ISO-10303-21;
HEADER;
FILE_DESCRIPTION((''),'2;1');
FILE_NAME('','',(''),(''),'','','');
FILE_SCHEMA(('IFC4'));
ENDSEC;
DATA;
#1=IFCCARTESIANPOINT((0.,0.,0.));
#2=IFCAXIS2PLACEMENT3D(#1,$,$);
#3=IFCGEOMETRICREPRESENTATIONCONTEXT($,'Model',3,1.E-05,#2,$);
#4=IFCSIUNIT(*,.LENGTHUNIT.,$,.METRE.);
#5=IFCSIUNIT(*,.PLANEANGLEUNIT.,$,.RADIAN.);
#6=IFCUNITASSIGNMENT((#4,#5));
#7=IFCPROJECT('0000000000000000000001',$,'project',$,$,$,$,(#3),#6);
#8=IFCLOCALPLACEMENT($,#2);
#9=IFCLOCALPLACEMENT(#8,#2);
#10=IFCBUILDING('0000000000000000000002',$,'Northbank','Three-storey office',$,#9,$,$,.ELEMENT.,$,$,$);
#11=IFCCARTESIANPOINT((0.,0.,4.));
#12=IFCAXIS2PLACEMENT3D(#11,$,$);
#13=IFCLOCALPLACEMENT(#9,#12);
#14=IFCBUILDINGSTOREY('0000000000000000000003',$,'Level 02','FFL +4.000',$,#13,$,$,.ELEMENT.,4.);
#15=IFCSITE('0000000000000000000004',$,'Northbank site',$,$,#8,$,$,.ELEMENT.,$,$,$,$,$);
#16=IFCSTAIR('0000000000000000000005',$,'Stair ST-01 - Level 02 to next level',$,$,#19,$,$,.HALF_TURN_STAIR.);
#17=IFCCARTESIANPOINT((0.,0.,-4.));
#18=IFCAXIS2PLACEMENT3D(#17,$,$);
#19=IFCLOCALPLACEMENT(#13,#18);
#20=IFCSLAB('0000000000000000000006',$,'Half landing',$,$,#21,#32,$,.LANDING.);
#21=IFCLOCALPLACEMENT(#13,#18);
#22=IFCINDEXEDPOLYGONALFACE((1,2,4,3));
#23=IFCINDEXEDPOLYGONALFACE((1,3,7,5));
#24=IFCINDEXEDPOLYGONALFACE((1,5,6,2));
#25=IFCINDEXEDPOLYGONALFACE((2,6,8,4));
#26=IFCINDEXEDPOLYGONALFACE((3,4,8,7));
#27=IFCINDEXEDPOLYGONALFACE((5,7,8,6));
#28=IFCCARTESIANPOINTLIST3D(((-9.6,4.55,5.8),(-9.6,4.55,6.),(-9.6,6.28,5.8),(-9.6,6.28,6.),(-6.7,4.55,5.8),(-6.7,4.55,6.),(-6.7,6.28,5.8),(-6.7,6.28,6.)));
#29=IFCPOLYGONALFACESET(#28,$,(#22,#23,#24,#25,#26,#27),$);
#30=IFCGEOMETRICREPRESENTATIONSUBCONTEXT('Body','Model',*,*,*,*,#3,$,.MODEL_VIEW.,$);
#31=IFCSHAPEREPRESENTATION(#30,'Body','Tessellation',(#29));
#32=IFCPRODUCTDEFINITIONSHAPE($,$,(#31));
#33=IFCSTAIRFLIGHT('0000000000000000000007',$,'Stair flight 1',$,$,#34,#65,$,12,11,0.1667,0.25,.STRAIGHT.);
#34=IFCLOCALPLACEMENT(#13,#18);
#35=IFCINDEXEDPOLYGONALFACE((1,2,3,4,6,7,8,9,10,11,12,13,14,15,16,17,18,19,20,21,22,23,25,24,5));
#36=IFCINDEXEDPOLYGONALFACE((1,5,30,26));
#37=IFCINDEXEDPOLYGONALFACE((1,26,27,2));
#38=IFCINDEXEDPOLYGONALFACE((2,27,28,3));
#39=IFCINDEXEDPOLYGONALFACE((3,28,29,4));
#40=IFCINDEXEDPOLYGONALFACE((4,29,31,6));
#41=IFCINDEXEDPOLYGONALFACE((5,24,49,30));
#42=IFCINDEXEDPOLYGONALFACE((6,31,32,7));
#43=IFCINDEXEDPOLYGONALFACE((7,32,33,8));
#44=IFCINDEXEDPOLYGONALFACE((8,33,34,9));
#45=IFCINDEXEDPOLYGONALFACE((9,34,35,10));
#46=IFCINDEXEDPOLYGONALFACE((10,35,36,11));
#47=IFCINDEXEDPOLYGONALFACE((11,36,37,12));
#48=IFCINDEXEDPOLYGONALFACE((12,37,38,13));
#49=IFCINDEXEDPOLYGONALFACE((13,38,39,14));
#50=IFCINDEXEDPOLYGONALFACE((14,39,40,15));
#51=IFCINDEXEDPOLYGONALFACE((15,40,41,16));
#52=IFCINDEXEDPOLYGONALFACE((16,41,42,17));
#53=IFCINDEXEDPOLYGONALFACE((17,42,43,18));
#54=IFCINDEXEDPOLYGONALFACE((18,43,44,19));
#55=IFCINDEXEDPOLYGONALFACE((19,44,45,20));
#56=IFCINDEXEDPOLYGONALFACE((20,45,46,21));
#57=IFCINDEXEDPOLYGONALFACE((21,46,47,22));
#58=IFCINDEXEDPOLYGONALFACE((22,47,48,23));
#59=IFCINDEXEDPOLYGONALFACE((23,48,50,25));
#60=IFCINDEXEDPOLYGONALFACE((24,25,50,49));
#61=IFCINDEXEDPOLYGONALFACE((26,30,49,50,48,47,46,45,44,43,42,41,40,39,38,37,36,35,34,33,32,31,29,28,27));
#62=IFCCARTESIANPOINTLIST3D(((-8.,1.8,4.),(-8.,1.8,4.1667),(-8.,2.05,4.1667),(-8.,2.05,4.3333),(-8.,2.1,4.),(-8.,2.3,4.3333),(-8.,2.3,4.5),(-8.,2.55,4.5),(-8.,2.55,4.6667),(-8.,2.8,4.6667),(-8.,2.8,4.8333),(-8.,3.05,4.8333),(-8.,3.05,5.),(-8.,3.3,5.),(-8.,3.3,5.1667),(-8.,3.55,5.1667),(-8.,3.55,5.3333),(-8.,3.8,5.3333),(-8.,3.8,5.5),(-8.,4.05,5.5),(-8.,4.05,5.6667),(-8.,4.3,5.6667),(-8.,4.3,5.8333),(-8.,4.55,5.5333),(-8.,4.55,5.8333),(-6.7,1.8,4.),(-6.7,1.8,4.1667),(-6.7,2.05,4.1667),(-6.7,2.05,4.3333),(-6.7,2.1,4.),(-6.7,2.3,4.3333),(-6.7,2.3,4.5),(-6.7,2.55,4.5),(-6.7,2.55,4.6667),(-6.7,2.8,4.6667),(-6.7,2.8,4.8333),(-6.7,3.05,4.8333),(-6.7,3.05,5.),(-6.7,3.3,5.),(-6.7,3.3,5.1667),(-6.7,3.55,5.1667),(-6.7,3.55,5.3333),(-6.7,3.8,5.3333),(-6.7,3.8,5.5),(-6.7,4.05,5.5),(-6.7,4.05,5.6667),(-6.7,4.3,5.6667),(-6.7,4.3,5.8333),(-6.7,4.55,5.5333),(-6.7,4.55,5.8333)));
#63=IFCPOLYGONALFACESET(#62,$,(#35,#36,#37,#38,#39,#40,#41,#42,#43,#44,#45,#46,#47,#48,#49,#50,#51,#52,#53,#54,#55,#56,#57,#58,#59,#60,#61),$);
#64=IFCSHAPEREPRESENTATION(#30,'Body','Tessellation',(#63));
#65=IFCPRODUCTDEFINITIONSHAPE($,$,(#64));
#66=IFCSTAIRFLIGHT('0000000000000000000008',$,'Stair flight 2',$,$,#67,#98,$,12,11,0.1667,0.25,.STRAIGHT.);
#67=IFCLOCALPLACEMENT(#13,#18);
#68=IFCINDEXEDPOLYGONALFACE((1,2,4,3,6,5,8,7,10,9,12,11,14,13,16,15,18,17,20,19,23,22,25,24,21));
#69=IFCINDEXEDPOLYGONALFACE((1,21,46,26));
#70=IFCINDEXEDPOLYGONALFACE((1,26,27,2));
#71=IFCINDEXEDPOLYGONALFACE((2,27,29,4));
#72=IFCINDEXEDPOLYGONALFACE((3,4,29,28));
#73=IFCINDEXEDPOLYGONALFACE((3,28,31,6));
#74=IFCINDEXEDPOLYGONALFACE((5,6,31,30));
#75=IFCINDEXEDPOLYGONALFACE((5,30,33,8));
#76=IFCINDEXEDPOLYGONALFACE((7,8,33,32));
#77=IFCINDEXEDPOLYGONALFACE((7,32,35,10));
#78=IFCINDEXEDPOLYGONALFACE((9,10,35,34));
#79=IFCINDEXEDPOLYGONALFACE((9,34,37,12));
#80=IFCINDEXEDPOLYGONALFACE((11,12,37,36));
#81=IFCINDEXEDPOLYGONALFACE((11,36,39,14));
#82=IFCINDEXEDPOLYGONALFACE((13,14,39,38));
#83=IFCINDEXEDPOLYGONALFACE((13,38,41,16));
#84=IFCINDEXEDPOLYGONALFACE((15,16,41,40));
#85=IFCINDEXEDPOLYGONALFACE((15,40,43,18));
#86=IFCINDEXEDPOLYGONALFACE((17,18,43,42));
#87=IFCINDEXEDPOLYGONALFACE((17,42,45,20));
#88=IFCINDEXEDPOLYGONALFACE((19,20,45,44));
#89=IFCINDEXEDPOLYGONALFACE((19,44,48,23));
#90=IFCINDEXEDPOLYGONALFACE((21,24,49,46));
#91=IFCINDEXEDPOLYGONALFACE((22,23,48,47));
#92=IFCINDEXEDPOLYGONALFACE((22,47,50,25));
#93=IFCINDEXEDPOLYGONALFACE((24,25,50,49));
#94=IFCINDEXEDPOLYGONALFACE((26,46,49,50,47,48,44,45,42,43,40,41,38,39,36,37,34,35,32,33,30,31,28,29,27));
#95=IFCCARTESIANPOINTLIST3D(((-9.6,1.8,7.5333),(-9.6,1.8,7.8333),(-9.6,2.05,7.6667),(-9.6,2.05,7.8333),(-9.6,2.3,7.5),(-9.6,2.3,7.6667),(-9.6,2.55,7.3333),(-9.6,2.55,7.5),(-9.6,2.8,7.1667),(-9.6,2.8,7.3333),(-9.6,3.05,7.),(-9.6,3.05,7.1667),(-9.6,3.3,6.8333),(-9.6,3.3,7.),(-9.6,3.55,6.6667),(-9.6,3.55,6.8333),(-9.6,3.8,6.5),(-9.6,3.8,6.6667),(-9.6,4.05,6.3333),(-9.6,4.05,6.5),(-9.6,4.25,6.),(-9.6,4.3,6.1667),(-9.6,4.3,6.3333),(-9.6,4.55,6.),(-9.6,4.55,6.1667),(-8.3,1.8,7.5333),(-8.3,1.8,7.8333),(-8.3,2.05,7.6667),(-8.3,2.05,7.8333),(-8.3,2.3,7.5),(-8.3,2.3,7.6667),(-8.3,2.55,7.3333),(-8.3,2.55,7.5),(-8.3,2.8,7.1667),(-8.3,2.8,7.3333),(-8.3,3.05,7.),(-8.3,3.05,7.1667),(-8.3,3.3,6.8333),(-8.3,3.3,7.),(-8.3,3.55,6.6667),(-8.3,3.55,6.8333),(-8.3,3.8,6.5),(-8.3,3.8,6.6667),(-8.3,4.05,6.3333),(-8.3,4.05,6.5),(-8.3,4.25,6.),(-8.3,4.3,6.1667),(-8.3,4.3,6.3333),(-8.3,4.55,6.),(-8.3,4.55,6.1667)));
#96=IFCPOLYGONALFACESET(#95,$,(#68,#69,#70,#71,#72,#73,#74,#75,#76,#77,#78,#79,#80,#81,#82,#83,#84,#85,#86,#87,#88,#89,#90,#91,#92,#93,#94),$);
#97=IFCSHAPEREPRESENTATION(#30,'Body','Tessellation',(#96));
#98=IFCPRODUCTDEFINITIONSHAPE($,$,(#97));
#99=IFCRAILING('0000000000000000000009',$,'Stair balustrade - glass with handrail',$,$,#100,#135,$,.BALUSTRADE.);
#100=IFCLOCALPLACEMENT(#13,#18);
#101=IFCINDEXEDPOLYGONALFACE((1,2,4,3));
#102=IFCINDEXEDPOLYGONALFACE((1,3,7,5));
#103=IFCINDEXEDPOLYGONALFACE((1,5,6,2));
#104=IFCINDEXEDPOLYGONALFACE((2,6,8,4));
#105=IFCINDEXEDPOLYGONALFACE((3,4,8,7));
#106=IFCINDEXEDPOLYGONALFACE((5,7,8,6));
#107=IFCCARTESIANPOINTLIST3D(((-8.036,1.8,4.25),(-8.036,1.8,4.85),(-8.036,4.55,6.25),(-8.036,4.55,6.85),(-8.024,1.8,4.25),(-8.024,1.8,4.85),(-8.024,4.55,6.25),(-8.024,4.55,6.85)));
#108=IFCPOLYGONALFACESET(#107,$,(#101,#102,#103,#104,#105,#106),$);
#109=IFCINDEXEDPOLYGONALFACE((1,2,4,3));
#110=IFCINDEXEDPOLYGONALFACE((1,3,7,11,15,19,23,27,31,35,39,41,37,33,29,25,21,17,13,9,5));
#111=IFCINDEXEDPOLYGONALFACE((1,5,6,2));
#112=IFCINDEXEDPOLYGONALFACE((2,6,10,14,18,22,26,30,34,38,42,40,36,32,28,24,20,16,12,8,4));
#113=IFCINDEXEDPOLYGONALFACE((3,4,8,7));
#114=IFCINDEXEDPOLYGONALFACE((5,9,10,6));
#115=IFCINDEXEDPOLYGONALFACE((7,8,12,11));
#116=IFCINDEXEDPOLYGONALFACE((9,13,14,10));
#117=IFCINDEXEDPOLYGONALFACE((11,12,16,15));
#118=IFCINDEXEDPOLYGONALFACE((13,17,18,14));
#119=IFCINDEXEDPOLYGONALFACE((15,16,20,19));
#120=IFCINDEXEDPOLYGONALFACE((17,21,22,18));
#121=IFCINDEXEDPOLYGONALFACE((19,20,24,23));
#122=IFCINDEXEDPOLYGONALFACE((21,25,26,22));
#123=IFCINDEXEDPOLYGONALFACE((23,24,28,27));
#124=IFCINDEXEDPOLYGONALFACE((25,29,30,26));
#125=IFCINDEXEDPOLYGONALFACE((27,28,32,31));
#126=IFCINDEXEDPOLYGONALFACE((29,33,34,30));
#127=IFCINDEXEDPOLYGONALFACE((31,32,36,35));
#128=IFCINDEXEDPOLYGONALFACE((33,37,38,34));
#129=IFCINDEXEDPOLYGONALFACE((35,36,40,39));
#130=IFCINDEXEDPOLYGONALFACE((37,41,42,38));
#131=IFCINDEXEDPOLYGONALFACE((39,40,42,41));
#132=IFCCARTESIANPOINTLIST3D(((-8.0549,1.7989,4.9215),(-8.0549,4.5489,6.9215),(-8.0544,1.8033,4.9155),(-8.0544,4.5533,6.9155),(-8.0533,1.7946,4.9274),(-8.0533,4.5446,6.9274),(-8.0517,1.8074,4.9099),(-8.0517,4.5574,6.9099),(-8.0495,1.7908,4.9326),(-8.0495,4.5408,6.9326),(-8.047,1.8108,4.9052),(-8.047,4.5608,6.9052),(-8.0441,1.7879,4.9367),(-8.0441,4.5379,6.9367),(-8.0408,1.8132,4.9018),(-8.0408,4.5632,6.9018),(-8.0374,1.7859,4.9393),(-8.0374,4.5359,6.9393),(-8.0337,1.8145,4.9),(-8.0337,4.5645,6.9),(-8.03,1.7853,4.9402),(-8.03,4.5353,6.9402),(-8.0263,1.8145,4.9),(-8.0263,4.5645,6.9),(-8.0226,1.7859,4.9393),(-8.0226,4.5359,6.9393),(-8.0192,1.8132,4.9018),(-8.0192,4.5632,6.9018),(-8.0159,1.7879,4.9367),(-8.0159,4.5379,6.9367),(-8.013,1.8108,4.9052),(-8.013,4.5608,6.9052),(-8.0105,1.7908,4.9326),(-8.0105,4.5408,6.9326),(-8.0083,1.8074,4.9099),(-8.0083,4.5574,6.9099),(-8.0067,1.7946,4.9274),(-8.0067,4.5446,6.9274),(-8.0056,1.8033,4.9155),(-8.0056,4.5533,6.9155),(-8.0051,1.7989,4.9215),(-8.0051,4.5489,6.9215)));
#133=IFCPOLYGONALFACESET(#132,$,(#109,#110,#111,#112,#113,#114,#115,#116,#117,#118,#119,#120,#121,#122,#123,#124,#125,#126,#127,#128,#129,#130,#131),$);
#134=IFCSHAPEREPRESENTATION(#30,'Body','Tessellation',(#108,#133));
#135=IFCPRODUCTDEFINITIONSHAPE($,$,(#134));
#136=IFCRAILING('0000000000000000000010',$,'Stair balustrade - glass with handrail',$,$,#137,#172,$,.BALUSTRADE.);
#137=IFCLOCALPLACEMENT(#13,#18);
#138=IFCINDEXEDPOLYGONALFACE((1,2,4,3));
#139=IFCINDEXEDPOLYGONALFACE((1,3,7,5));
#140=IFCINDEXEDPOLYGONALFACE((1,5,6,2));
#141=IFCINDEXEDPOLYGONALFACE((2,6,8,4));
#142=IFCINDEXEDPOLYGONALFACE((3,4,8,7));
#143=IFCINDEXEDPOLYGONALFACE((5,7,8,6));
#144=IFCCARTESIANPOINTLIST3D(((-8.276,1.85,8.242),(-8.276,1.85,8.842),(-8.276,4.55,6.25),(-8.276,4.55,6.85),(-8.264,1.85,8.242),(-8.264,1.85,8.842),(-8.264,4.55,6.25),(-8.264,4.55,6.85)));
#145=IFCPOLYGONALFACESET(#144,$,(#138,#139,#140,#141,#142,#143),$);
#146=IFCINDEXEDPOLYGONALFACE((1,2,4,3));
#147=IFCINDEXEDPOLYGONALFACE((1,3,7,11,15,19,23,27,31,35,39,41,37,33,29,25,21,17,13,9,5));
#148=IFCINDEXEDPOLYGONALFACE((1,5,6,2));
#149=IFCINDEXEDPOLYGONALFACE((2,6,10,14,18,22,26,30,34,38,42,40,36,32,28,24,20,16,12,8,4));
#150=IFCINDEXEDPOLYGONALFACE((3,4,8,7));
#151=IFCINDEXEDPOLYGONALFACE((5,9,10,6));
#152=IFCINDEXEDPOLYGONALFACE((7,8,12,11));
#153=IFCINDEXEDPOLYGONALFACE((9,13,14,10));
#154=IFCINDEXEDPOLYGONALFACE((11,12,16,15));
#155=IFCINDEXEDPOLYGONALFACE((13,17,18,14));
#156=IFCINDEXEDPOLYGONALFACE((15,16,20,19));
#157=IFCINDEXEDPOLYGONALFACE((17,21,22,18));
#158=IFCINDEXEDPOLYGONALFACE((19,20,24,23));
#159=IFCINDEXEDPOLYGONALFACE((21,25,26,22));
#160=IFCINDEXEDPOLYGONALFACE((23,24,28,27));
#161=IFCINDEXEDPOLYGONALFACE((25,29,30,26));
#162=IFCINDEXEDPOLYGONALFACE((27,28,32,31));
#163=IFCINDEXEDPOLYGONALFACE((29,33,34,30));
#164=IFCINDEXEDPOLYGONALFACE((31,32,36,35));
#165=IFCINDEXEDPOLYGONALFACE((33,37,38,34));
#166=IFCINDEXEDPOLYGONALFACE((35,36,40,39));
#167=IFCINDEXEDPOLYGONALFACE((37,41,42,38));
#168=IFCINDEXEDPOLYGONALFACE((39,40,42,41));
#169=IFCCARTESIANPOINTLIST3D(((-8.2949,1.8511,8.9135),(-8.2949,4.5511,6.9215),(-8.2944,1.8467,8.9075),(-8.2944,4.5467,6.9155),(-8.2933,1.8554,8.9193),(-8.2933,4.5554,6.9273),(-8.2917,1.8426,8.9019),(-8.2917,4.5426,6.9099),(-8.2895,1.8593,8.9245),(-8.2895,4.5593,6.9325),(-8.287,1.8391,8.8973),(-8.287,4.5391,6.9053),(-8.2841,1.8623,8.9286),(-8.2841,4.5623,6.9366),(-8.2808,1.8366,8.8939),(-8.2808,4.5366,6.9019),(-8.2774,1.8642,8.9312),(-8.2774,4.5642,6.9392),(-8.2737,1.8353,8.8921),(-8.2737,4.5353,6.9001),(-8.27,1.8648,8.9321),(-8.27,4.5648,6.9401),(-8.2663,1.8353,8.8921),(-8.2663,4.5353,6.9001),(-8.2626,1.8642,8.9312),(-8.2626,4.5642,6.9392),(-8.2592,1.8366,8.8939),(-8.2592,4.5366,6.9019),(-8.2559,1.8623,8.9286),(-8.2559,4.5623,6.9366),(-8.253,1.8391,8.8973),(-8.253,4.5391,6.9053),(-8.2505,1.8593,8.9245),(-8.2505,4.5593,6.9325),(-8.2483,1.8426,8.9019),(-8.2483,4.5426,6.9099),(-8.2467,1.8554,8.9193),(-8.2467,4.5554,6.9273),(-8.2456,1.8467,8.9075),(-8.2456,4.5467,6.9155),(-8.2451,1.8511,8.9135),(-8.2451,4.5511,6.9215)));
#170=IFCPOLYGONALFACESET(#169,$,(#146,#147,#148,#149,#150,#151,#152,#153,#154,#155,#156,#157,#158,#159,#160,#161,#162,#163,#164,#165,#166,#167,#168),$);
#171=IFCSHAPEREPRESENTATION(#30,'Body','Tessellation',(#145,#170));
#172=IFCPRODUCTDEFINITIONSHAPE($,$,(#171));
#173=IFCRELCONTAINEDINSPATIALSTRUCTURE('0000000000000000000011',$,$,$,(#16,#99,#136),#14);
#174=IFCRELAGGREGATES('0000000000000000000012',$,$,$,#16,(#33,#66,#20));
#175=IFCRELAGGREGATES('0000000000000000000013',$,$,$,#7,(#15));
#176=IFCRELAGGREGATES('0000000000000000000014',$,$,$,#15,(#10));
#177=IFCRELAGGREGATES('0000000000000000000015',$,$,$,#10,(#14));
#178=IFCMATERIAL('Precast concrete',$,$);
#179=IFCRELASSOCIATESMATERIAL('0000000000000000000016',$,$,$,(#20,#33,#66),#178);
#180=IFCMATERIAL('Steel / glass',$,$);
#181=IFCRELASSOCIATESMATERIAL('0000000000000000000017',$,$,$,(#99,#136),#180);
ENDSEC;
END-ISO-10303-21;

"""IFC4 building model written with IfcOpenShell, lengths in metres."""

from ifc_helpers import new_model, si_unit, frame, origin, place, context, subcontext, project, spatial, polyline, rectangle, circle, outline, extrude, material, element, aggregate, save


model = new_model("IFC4")

# Units and contexts
model_context = context("Model", 3, precision=1e-05, world=origin())
body_context = subcontext(model_context, "Body", "Model", "MODEL_VIEW")
ifc_project = project(units=[si_unit("LENGTHUNIT", "METRE"), si_unit("PLANEANGLEUNIT", "RADIAN")], contexts=[model_context])

# Site, building, storey
site_placement = place(None, origin())
site = spatial("IfcSite", under=ifc_project, at=site_placement, Name="Northbank site", CompositionType="ELEMENT")
building_placement = place(site_placement, origin())
building = spatial("IfcBuilding", under=site, at=building_placement, Name="Northbank", Description="Three-storey office", CompositionType="ELEMENT")
storey_placement = place(building_placement, frame((0.0, 0.0, 4.0)))
storey = spatial("IfcBuildingStorey", under=building, at=storey_placement, Name="Level 02", Description="FFL +4.000", CompositionType="ELEMENT", Elevation=4.0)

# Stair, slab
stair_placement = place(storey_placement, frame((0.0, 0.0, -4.0)))
stair = element("IfcStair", 1, at=stair_placement, inside=storey, Name="Stair ST-01 - Level 02 to next level", PredefinedType="HALF_TURN_STAIR")
ifc_material_1 = material(Name="Precast concrete")
slab_placement = place(storey_placement, frame((0.0, 0.0, -4.0)))
slab = element("IfcSlab", 2, at=slab_placement, material=ifc_material_1, Name="Half landing", PredefinedType="LANDING", context=body_context, shape_type="SweptSolid", body=[
    extrude(rectangle(XDim=2.9, YDim=1.73), frame((-8.15, 5.415, 5.8)), (0.0, 0.0, 1.0), 0.2),
])

# Stair flights
stair_flight_1_placement = place(storey_placement, frame((0.0, 0.0, -4.0)))
stair_flight_1 = element("IfcStairFlight", 3, at=stair_flight_1_placement, material=ifc_material_1, Name="Stair flight 1", NumberOfRisers=12, NumberOfTreads=11, PredefinedType="STRAIGHT", RiserHeight=0.1667, TreadLength=0.25, context=body_context, shape_type="SweptSolid", body=[
    extrude(outline(polyline([(1.8, 4.0), (1.8, 4.1667), (2.05, 4.1667), (2.05, 4.3333), (2.3, 4.3333), (2.3, 4.5), (2.55, 4.5), (2.55, 4.6667), (2.8, 4.6667), (2.8, 4.8333), (3.05, 4.8333), (3.05, 5.0), (3.3, 5.0), (3.3, 5.1667), (3.55, 5.1667), (3.55, 5.3333), (3.8, 5.3333), (3.8, 5.5), (4.05, 5.5), (4.05, 5.6667), (4.3, 5.6667), (4.3, 5.8333), (4.55, 5.8333), (4.55, 5.5333), (2.1, 4.0), (1.8, 4.0)])), frame((-8.0, 0.0, 0.0), z_axis=(1.0, 0.0, 0.0), x_axis=(0.0, 1.0, 0.0)), (0.0, 0.0, 1.0), 1.3),
])
stair_flight_2_placement = place(storey_placement, frame((0.0, 0.0, -4.0)))
stair_flight_2 = element("IfcStairFlight", 4, at=stair_flight_2_placement, material=ifc_material_1, Name="Stair flight 2", NumberOfRisers=12, NumberOfTreads=11, PredefinedType="STRAIGHT", RiserHeight=0.1667, TreadLength=0.25, context=body_context, shape_type="SweptSolid", body=[
    extrude(outline(polyline([(4.55, 6.0), (4.55, 6.1667), (4.3, 6.1667), (4.3, 6.3333), (4.05, 6.3333), (4.05, 6.5), (3.8, 6.5), (3.8, 6.6667), (3.55, 6.6667), (3.55, 6.8333), (3.3, 6.8333), (3.3, 7.0), (3.05, 7.0), (3.05, 7.1667), (2.8, 7.1667), (2.8, 7.3333), (2.55, 7.3333), (2.55, 7.5), (2.3, 7.5), (2.3, 7.6667), (2.05, 7.6667), (2.05, 7.8333), (1.8, 7.8333), (1.8, 7.5333), (4.25, 6.0), (4.55, 6.0)])), frame((-9.6, 0.0, 0.0), z_axis=(1.0, 0.0, 0.0), x_axis=(0.0, 1.0, 0.0)), (0.0, 0.0, 1.0), 1.3),
])
aggregate(stair, [stair_flight_1, stair_flight_2, slab])

# Railings
ifc_material_2 = material(Name="Steel / glass")
railing_1_placement = place(storey_placement, frame((0.0, 0.0, -4.0)))
element("IfcRailing", 5, at=railing_1_placement, inside=storey, material=ifc_material_2, Name="Stair balustrade - glass with handrail", PredefinedType="BALUSTRADE", context=body_context, shape_type="SweptSolid", body=[
    extrude(outline(polyline([(1.8, 4.25), (4.55, 6.25), (4.55, 6.85), (1.8, 4.85), (1.8, 4.25)])), frame((-8.036, 0.0, 0.0), z_axis=(1.0, 0.0, 0.0), x_axis=(0.0, 1.0, 0.0)), (0.0, 0.0, 1.0), 0.012),
    extrude(circle(Radius=0.025), frame((-8.03, 1.8, 4.92), z_axis=(0.0, 0.808736, 0.588172), x_axis=(0.0, -0.588172, 0.808736)), (0.0, 0.0, 1.0), 3.4004),
])
railing_2_placement = place(storey_placement, frame((0.0, 0.0, -4.0)))
element("IfcRailing", 6, at=railing_2_placement, inside=storey, material=ifc_material_2, Name="Stair balustrade - glass with handrail", PredefinedType="BALUSTRADE", context=body_context, shape_type="SweptSolid", body=[
    extrude(outline(polyline([(4.55, 6.25), (1.85, 8.242), (1.85, 8.842), (4.55, 6.85), (4.55, 6.25)])), frame((-8.276, 0.0, 0.0), z_axis=(1.0, 0.0, 0.0), x_axis=(0.0, 1.0, 0.0)), (0.0, 0.0, 1.0), 0.012),
    extrude(circle(Radius=0.025), frame((-8.27, 4.55, 6.92), z_axis=(0.0, -0.804696, 0.593687), x_axis=(0.0, 0.593687, 0.804696)), (0.0, 0.0, 1.0), 3.3553),
])

save(model, "model.ifc")
